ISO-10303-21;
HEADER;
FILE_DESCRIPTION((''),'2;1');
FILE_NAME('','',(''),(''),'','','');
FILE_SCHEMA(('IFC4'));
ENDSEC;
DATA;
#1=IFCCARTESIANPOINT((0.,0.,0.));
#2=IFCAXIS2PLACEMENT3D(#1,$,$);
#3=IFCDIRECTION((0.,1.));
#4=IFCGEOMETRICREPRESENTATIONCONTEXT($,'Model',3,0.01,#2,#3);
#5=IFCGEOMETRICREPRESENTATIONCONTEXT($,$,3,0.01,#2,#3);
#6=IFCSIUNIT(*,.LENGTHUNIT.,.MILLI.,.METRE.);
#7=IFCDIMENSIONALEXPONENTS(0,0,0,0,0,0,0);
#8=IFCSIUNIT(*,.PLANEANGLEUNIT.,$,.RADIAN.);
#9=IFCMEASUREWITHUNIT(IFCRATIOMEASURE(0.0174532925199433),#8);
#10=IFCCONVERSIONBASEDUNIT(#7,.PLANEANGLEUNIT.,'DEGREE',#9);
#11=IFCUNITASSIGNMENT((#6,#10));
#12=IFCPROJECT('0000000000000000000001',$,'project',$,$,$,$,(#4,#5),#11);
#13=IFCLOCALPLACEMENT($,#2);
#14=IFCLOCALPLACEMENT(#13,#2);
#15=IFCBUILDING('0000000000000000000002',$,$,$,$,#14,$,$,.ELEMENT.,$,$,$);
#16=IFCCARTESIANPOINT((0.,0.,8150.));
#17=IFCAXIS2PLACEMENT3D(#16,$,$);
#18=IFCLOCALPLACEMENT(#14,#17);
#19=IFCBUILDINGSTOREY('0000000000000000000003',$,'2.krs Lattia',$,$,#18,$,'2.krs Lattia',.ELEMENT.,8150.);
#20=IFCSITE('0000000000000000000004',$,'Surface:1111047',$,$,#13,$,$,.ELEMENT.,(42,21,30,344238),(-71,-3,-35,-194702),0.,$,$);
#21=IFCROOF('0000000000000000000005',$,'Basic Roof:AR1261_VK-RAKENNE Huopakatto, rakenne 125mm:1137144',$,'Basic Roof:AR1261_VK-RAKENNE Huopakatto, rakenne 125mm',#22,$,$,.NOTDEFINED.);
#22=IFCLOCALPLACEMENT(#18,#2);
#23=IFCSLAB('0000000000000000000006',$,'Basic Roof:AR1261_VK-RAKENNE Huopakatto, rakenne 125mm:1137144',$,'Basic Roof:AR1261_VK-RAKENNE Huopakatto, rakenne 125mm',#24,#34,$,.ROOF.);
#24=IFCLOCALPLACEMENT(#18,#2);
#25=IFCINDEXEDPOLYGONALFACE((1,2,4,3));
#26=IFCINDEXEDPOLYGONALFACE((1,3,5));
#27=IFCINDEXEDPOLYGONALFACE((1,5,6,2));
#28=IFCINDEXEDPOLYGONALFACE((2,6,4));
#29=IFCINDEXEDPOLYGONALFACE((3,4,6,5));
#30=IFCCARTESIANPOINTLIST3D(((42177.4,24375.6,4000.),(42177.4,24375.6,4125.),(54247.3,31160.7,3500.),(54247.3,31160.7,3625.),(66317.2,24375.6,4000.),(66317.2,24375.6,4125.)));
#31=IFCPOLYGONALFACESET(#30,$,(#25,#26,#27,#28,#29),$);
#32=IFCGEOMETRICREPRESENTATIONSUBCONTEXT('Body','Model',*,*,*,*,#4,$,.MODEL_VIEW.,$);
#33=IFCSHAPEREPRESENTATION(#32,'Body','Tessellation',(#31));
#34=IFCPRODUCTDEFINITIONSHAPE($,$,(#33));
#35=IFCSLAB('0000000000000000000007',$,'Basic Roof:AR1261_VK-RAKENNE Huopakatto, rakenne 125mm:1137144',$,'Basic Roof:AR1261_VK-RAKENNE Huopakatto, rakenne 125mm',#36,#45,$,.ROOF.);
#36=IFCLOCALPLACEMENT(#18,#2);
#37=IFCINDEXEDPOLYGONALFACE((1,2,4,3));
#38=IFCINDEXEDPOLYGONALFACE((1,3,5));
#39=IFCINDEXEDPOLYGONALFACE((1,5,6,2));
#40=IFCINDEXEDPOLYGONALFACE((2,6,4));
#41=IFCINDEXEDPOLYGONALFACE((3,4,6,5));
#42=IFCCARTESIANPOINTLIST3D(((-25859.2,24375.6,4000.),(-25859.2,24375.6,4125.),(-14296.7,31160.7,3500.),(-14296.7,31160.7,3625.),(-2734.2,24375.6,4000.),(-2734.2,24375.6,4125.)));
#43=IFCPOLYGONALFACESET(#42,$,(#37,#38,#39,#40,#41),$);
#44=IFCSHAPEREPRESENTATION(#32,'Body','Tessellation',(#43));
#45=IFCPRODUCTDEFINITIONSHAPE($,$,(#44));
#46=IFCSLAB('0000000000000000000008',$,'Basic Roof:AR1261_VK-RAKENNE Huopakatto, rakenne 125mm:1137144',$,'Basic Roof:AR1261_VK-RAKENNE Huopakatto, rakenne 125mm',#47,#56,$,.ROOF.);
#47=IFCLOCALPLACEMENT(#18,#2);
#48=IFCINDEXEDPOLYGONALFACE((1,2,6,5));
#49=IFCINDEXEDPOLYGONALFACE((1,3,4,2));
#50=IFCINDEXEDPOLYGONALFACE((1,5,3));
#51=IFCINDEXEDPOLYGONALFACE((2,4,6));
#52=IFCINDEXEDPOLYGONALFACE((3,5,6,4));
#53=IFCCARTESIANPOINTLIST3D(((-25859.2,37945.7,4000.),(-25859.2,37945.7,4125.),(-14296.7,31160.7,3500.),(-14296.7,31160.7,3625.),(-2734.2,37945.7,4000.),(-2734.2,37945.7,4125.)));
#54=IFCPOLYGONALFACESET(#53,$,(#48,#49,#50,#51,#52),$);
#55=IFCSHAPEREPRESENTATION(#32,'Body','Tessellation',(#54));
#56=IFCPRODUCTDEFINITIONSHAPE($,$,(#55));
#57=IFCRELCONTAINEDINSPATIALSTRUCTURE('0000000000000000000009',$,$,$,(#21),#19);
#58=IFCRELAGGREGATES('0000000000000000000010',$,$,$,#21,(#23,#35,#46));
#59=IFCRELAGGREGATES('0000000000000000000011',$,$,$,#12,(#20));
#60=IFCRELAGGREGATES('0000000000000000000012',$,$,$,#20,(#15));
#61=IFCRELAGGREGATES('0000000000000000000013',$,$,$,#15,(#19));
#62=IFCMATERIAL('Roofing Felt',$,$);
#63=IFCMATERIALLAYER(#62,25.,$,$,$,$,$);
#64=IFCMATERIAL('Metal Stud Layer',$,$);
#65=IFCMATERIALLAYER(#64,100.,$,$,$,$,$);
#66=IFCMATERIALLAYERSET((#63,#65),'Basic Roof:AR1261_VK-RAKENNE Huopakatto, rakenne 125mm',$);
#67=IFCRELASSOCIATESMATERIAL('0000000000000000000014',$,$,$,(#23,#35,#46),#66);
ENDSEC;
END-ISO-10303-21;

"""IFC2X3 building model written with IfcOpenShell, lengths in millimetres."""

from ifc_helpers import new_model, entity, si_unit, converted_unit, direction, frame, origin, place, context, subcontext, project, spatial, polyline, outline, extrude, material, layer, layer_set, element, aggregate, save


model = new_model("IFC2X3")

# Units and contexts
model_context = context("Model", 3, precision=0.01, world=origin(), true_north=direction((0.0, 1.0)))
context_of_model = context(None, 3, precision=0.01, world=origin(), true_north=direction((0.0, 1.0)))
body_context = subcontext(model_context, "Body", "Model", "MODEL_VIEW")
ifc_project = project(units=[si_unit("LENGTHUNIT", "METRE", prefix="MILLI"), converted_unit("PLANEANGLEUNIT", "DEGREE", entity("IfcRatioMeasure", 0.0174532925199433), si_unit("PLANEANGLEUNIT", "RADIAN"), dimensions=[0, 0, 0, 0, 0, 0, 0])], contexts=[model_context, context_of_model])

# Site, building, storey
site_placement = place(None, origin())
site = spatial("IfcSite", under=ifc_project, at=site_placement, Name="Surface:1111047", CompositionType="ELEMENT", RefLatitude=(42, 21, 30, 344238), RefLongitude=(-71, -3, -35, -194702), RefElevation=0.0)
building_placement = place(site_placement, origin())
building = spatial("IfcBuilding", under=site, at=building_placement, CompositionType="ELEMENT")
storey_placement = place(building_placement, frame((0.0, 0.0, 8150.0)))
storey = spatial("IfcBuildingStorey", under=building, at=storey_placement, Name="2.krs Lattia", LongName="2.krs Lattia", CompositionType="ELEMENT", Elevation=8150.0)

# Shared definitions
ifc_material_1 = material(Name="Roofing Felt")
ifc_layer_1 = layer(ifc_material_1, 25.0)
ifc_material_2 = material(Name="Metal Stud Layer")
ifc_layer_2 = layer(ifc_material_2, 100.0)
ifc_layer_set = layer_set([ifc_layer_1, ifc_layer_2], Name="Basic Roof:AR1261_VK-RAKENNE Huopakatto, rakenne 125mm")

# Roof, slabs
roof_1_placement = place(storey_placement, frame((-25859.2, 24375.6, 3500.0)))
roof_1 = element("IfcRoof", 1, at=roof_1_placement, inside=storey, Name="Basic Roof:AR1261_VK-RAKENNE Huopakatto, rakenne 125mm:1137144", ObjectType="Basic Roof:AR1261_VK-RAKENNE Huopakatto, rakenne 125mm", ShapeType="NOTDEFINED")
slab_1_placement = place(roof_1_placement, origin())
slab_1 = element("IfcSlab", 2, at=slab_1_placement, material=ifc_layer_set, Name="Basic Roof:AR1261_VK-RAKENNE Huopakatto, rakenne 125mm:1137144", ObjectType="Basic Roof:AR1261_VK-RAKENNE Huopakatto, rakenne 125mm", PredefinedType="ROOF", context=body_context, shape_type="SweptSolid", body=[
    extrude(outline(polyline([(12069.9, 0.0), (0.0, 6803.5), (-12069.9, 0.0), (12069.9, 0.0)])), frame((80106.4, 0.0, 500.0), z_axis=(0.0, 0.073492, 0.997296), x_axis=(1.0, 0.0, 0.0)), (0.0, -0.073492, 0.997296), 125.0),
])
slab_2_placement = place(roof_1_placement, origin())
slab_2 = element("IfcSlab", 3, at=slab_2_placement, material=ifc_layer_set, Name="Basic Roof:AR1261_VK-RAKENNE Huopakatto, rakenne 125mm:1137144", ObjectType="Basic Roof:AR1261_VK-RAKENNE Huopakatto, rakenne 125mm", PredefinedType="ROOF", context=body_context, shape_type="SweptSolid", body=[
    extrude(outline(polyline([(-11562.5, -3401.7), (11562.5, -3401.7), (0.0, 3401.7), (-11562.5, -3401.7)])), frame((11562.5, 3392.5, 250.0), z_axis=(0.0, 0.073492, 0.997296), x_axis=(1.0, 0.0, 0.0)), (0.0, -0.073492, 0.997296), 125.0),
])
slab_3_placement = place(roof_1_placement, origin())
slab_3 = element("IfcSlab", 4, at=slab_3_placement, material=ifc_layer_set, Name="Basic Roof:AR1261_VK-RAKENNE Huopakatto, rakenne 125mm:1137144", ObjectType="Basic Roof:AR1261_VK-RAKENNE Huopakatto, rakenne 125mm", PredefinedType="ROOF", context=body_context, shape_type="SweptSolid", body=[
    extrude(outline(polyline([(-11562.5, 0.0), (0.0, -6803.5), (11562.5, 0.0), (-11562.5, 0.0)])), frame((11562.5, 13570.1, 500.0), z_axis=(0.0, -0.073492, 0.997296), x_axis=(1.0, 0.0, 0.0)), (0.0, 0.073492, 0.997296), 125.0),
])
aggregate(roof_1, [slab_1, slab_2, slab_3])

save(model, "model.ifc")
